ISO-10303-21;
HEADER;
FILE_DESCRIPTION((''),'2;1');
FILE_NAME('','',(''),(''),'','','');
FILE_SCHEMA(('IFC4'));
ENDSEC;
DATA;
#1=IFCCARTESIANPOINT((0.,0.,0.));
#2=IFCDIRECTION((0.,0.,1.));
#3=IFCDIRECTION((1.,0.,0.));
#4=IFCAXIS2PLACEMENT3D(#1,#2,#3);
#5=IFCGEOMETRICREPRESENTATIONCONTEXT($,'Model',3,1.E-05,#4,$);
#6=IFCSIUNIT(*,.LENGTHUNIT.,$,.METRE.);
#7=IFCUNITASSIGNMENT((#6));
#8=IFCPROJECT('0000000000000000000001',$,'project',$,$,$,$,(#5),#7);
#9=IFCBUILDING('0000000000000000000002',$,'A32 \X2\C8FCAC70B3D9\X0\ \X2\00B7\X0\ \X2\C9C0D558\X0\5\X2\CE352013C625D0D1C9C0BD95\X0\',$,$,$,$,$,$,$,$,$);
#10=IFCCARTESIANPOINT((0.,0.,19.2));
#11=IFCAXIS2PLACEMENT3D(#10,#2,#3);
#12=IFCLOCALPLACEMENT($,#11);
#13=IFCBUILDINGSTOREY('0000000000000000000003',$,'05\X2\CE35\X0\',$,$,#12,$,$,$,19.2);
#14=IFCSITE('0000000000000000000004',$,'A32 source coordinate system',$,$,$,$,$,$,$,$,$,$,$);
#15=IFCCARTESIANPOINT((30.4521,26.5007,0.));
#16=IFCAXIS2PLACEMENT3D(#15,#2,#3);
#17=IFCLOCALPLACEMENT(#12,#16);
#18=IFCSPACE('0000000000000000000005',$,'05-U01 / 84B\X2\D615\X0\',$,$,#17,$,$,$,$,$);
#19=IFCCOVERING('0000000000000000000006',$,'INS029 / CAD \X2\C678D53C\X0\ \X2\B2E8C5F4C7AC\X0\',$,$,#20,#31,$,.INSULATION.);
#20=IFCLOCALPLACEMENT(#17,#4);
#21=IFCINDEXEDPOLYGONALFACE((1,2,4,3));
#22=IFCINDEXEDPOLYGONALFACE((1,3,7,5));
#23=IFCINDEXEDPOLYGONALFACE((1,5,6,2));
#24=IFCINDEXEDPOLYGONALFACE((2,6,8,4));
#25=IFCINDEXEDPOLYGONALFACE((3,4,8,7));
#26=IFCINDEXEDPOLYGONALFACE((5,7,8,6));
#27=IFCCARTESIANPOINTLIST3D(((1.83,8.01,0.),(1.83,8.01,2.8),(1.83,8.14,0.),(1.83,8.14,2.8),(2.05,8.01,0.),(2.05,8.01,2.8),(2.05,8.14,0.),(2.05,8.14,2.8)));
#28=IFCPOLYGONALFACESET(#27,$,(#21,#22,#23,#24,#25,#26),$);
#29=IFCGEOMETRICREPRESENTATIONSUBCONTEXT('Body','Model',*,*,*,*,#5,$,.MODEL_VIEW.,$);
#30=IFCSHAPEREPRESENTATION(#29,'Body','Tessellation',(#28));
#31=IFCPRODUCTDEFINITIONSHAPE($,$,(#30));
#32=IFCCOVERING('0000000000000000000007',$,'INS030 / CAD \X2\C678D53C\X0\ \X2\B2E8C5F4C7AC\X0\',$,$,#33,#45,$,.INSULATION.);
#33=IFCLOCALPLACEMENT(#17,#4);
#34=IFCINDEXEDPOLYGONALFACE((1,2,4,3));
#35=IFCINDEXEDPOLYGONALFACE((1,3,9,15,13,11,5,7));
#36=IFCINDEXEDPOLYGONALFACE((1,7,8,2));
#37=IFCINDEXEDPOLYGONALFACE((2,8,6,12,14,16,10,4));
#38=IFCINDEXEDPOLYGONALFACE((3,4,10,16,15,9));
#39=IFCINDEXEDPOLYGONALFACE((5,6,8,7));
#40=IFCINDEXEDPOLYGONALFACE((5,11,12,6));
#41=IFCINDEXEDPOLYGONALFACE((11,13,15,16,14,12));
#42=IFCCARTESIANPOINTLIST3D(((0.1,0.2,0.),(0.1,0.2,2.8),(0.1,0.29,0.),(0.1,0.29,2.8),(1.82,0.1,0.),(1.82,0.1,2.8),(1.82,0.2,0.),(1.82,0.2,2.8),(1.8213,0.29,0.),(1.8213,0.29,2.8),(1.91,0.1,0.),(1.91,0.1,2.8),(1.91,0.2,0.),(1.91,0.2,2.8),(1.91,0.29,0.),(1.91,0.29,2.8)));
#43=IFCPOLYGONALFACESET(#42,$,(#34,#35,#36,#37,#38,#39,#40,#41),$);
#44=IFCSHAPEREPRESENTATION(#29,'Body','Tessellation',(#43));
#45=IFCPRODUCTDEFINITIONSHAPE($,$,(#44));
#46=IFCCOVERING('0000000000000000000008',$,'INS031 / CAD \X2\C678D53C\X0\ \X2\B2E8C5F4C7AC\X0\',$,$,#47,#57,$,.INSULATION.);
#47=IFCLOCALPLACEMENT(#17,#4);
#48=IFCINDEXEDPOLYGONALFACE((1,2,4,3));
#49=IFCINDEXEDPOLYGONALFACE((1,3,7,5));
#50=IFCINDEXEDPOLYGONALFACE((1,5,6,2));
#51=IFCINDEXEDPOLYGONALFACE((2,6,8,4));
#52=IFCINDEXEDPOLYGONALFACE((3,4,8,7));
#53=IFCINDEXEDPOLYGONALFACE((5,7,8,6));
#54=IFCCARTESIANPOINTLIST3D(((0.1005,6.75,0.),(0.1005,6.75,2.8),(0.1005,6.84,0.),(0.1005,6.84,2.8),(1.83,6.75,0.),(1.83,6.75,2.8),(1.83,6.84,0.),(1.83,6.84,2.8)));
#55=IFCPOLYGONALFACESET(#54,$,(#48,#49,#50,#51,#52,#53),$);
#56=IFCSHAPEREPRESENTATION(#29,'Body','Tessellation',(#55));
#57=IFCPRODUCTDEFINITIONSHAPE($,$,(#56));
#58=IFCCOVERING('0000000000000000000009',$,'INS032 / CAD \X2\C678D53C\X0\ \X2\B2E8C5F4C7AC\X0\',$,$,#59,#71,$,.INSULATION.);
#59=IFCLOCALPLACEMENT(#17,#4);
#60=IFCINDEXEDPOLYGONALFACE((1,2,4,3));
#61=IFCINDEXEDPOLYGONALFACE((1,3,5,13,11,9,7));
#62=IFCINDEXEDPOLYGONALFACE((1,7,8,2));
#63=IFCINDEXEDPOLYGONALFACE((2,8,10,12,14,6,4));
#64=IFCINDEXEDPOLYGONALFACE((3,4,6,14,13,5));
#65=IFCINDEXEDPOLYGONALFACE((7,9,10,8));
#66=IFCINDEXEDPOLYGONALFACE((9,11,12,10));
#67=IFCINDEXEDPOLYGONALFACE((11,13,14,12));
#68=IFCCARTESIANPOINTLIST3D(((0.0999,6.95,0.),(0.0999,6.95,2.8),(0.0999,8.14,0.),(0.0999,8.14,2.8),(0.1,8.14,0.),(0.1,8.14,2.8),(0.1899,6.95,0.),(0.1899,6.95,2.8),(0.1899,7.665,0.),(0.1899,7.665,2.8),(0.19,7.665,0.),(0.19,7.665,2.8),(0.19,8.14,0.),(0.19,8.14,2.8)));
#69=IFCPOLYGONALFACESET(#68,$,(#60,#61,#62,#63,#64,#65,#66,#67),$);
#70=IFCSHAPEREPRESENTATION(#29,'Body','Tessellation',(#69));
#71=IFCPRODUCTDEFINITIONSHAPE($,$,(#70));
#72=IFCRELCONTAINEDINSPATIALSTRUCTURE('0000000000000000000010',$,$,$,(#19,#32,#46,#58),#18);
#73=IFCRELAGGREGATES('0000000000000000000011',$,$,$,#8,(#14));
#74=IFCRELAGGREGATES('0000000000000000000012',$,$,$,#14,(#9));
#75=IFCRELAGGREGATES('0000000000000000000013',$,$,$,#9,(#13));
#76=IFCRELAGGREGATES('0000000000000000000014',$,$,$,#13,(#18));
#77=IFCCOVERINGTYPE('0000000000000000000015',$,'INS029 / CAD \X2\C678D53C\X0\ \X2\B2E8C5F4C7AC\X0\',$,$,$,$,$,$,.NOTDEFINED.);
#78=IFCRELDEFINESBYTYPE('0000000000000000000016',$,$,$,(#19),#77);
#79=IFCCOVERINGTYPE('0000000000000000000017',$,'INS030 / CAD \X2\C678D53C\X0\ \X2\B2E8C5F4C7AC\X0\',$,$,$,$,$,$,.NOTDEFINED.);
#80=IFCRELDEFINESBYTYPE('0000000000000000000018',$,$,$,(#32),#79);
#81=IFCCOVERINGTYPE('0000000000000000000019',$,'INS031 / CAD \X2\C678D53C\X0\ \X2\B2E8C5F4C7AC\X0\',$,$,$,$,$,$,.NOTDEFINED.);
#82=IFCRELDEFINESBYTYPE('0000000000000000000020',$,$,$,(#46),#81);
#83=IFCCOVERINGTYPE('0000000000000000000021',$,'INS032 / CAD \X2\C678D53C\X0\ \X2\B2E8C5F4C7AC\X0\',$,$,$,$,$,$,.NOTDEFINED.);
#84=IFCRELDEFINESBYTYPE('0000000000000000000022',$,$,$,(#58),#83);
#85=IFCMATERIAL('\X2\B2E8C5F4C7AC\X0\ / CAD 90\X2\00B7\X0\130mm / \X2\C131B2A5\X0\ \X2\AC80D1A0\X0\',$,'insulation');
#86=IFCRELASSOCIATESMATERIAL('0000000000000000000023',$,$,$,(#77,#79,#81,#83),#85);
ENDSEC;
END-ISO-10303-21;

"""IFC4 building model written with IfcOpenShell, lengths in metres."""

from ifc_helpers import new_model, si_unit, frame, origin, origin_with_axes, place, context, subcontext, project, spatial, polyline, outline, extrude, source, transform, mapped, material, type_object, type_shapes, element, save


model = new_model("IFC4")

# Units and contexts
model_context = context("Model", 3, precision=1e-05, world=origin_with_axes())
body_context = subcontext(model_context, "Body", "Model", "MODEL_VIEW")
ifc_project = project(units=[si_unit("LENGTHUNIT", "METRE")], contexts=[model_context])

# Site, building, storey, space
storey_placement = place(None, frame((0.0, 0.0, 19.2), z_axis=(0.0, 0.0, 1.0), x_axis=(1.0, 0.0, 0.0)))
space_placement = place(storey_placement, frame((30.4521, 26.5007, 0.0), z_axis=(0.0, 0.0, 1.0), x_axis=(1.0, 0.0, 0.0)))
site = spatial("IfcSite", under=ifc_project, Name="A32 source coordinate system")
building = spatial("IfcBuilding", under=site, Name="A32 주거동 · 지하5층–옥탑지붕")
storey = spatial("IfcBuildingStorey", under=building, at=storey_placement, Name="05층", Elevation=19.2)
space = spatial("IfcSpace", under=storey, at=space_placement, Name="05-U01 / 84B형")

# Coverings
ifc_material = material(Name="단열재 / CAD 90·130mm / 성능 검토", Category="insulation")
covering_type_1 = type_object("IfcCoveringType", Name="INS029 / CAD 외피 단열재", PredefinedType="NOTDEFINED", material=ifc_material)
shared_shape_1 = source(origin(), body_context, "Body", "SweptSolid", [
    extrude(outline(polyline([(1.83, 8.01), (1.83, 8.14), (2.05, 8.14), (2.05, 8.01), (1.83, 8.01)])), origin(), (0.0, 0.0, 1.0), 2.8),
])
type_shapes(covering_type_1, [shared_shape_1])
covering_1_placement = place(space_placement, origin_with_axes())
element("IfcCovering", 1, at=covering_1_placement, inside=space, type_object=covering_type_1, Name="INS029 / CAD 외피 단열재", PredefinedType="INSULATION", context=body_context, shape_type="MappedRepresentation", body=[
    mapped(shared_shape_1, transform((0.0, 0.0, 0.0), scale=1.0)),
])
covering_type_2 = type_object("IfcCoveringType", Name="INS030 / CAD 외피 단열재", PredefinedType="NOTDEFINED", material=ifc_material)
shared_shape_2 = source(origin(), body_context, "Body", "SweptSolid", [
    extrude(outline(polyline([(1.91, 0.2), (1.91, 0.1), (1.82, 0.1), (1.82, 0.2), (0.1, 0.2), (0.1, 0.29), (1.8213, 0.29), (1.91, 0.29), (1.91, 0.2)])), origin(), (0.0, 0.0, 1.0), 2.8),
])
type_shapes(covering_type_2, [shared_shape_2])
covering_2_placement = place(space_placement, origin_with_axes())
element("IfcCovering", 2, at=covering_2_placement, inside=space, type_object=covering_type_2, Name="INS030 / CAD 외피 단열재", PredefinedType="INSULATION", context=body_context, shape_type="MappedRepresentation", body=[
    mapped(shared_shape_2, transform((0.0, 0.0, 0.0), scale=1.0)),
])
covering_type_3 = type_object("IfcCoveringType", Name="INS031 / CAD 외피 단열재", PredefinedType="NOTDEFINED", material=ifc_material)
shared_shape_3 = source(origin(), body_context, "Body", "SweptSolid", [
    extrude(outline(polyline([(1.83, 6.75), (0.1005, 6.75), (0.1005, 6.84), (1.83, 6.84), (1.83, 6.75)])), origin(), (0.0, 0.0, 1.0), 2.8),
])
type_shapes(covering_type_3, [shared_shape_3])
covering_3_placement = place(space_placement, origin_with_axes())
element("IfcCovering", 3, at=covering_3_placement, inside=space, type_object=covering_type_3, Name="INS031 / CAD 외피 단열재", PredefinedType="INSULATION", context=body_context, shape_type="MappedRepresentation", body=[
    mapped(shared_shape_3, transform((0.0, 0.0, 0.0), scale=1.0)),
])
covering_type_4 = type_object("IfcCoveringType", Name="INS032 / CAD 외피 단열재", PredefinedType="NOTDEFINED", material=ifc_material)
shared_shape_4 = source(origin(), body_context, "Body", "SweptSolid", [
    extrude(outline(polyline([(0.1899, 6.95), (0.0999, 6.95), (0.0999, 8.14), (0.1, 8.14), (0.19, 8.14), (0.19, 7.665), (0.1899, 7.665), (0.1899, 6.95)])), origin(), (0.0, 0.0, 1.0), 2.8),
])
type_shapes(covering_type_4, [shared_shape_4])
covering_4_placement = place(space_placement, origin_with_axes())
element("IfcCovering", 4, at=covering_4_placement, inside=space, type_object=covering_type_4, Name="INS032 / CAD 외피 단열재", PredefinedType="INSULATION", context=body_context, shape_type="MappedRepresentation", body=[
    mapped(shared_shape_4, transform((0.0, 0.0, 0.0), scale=1.0)),
])

save(model, "model.ifc")
